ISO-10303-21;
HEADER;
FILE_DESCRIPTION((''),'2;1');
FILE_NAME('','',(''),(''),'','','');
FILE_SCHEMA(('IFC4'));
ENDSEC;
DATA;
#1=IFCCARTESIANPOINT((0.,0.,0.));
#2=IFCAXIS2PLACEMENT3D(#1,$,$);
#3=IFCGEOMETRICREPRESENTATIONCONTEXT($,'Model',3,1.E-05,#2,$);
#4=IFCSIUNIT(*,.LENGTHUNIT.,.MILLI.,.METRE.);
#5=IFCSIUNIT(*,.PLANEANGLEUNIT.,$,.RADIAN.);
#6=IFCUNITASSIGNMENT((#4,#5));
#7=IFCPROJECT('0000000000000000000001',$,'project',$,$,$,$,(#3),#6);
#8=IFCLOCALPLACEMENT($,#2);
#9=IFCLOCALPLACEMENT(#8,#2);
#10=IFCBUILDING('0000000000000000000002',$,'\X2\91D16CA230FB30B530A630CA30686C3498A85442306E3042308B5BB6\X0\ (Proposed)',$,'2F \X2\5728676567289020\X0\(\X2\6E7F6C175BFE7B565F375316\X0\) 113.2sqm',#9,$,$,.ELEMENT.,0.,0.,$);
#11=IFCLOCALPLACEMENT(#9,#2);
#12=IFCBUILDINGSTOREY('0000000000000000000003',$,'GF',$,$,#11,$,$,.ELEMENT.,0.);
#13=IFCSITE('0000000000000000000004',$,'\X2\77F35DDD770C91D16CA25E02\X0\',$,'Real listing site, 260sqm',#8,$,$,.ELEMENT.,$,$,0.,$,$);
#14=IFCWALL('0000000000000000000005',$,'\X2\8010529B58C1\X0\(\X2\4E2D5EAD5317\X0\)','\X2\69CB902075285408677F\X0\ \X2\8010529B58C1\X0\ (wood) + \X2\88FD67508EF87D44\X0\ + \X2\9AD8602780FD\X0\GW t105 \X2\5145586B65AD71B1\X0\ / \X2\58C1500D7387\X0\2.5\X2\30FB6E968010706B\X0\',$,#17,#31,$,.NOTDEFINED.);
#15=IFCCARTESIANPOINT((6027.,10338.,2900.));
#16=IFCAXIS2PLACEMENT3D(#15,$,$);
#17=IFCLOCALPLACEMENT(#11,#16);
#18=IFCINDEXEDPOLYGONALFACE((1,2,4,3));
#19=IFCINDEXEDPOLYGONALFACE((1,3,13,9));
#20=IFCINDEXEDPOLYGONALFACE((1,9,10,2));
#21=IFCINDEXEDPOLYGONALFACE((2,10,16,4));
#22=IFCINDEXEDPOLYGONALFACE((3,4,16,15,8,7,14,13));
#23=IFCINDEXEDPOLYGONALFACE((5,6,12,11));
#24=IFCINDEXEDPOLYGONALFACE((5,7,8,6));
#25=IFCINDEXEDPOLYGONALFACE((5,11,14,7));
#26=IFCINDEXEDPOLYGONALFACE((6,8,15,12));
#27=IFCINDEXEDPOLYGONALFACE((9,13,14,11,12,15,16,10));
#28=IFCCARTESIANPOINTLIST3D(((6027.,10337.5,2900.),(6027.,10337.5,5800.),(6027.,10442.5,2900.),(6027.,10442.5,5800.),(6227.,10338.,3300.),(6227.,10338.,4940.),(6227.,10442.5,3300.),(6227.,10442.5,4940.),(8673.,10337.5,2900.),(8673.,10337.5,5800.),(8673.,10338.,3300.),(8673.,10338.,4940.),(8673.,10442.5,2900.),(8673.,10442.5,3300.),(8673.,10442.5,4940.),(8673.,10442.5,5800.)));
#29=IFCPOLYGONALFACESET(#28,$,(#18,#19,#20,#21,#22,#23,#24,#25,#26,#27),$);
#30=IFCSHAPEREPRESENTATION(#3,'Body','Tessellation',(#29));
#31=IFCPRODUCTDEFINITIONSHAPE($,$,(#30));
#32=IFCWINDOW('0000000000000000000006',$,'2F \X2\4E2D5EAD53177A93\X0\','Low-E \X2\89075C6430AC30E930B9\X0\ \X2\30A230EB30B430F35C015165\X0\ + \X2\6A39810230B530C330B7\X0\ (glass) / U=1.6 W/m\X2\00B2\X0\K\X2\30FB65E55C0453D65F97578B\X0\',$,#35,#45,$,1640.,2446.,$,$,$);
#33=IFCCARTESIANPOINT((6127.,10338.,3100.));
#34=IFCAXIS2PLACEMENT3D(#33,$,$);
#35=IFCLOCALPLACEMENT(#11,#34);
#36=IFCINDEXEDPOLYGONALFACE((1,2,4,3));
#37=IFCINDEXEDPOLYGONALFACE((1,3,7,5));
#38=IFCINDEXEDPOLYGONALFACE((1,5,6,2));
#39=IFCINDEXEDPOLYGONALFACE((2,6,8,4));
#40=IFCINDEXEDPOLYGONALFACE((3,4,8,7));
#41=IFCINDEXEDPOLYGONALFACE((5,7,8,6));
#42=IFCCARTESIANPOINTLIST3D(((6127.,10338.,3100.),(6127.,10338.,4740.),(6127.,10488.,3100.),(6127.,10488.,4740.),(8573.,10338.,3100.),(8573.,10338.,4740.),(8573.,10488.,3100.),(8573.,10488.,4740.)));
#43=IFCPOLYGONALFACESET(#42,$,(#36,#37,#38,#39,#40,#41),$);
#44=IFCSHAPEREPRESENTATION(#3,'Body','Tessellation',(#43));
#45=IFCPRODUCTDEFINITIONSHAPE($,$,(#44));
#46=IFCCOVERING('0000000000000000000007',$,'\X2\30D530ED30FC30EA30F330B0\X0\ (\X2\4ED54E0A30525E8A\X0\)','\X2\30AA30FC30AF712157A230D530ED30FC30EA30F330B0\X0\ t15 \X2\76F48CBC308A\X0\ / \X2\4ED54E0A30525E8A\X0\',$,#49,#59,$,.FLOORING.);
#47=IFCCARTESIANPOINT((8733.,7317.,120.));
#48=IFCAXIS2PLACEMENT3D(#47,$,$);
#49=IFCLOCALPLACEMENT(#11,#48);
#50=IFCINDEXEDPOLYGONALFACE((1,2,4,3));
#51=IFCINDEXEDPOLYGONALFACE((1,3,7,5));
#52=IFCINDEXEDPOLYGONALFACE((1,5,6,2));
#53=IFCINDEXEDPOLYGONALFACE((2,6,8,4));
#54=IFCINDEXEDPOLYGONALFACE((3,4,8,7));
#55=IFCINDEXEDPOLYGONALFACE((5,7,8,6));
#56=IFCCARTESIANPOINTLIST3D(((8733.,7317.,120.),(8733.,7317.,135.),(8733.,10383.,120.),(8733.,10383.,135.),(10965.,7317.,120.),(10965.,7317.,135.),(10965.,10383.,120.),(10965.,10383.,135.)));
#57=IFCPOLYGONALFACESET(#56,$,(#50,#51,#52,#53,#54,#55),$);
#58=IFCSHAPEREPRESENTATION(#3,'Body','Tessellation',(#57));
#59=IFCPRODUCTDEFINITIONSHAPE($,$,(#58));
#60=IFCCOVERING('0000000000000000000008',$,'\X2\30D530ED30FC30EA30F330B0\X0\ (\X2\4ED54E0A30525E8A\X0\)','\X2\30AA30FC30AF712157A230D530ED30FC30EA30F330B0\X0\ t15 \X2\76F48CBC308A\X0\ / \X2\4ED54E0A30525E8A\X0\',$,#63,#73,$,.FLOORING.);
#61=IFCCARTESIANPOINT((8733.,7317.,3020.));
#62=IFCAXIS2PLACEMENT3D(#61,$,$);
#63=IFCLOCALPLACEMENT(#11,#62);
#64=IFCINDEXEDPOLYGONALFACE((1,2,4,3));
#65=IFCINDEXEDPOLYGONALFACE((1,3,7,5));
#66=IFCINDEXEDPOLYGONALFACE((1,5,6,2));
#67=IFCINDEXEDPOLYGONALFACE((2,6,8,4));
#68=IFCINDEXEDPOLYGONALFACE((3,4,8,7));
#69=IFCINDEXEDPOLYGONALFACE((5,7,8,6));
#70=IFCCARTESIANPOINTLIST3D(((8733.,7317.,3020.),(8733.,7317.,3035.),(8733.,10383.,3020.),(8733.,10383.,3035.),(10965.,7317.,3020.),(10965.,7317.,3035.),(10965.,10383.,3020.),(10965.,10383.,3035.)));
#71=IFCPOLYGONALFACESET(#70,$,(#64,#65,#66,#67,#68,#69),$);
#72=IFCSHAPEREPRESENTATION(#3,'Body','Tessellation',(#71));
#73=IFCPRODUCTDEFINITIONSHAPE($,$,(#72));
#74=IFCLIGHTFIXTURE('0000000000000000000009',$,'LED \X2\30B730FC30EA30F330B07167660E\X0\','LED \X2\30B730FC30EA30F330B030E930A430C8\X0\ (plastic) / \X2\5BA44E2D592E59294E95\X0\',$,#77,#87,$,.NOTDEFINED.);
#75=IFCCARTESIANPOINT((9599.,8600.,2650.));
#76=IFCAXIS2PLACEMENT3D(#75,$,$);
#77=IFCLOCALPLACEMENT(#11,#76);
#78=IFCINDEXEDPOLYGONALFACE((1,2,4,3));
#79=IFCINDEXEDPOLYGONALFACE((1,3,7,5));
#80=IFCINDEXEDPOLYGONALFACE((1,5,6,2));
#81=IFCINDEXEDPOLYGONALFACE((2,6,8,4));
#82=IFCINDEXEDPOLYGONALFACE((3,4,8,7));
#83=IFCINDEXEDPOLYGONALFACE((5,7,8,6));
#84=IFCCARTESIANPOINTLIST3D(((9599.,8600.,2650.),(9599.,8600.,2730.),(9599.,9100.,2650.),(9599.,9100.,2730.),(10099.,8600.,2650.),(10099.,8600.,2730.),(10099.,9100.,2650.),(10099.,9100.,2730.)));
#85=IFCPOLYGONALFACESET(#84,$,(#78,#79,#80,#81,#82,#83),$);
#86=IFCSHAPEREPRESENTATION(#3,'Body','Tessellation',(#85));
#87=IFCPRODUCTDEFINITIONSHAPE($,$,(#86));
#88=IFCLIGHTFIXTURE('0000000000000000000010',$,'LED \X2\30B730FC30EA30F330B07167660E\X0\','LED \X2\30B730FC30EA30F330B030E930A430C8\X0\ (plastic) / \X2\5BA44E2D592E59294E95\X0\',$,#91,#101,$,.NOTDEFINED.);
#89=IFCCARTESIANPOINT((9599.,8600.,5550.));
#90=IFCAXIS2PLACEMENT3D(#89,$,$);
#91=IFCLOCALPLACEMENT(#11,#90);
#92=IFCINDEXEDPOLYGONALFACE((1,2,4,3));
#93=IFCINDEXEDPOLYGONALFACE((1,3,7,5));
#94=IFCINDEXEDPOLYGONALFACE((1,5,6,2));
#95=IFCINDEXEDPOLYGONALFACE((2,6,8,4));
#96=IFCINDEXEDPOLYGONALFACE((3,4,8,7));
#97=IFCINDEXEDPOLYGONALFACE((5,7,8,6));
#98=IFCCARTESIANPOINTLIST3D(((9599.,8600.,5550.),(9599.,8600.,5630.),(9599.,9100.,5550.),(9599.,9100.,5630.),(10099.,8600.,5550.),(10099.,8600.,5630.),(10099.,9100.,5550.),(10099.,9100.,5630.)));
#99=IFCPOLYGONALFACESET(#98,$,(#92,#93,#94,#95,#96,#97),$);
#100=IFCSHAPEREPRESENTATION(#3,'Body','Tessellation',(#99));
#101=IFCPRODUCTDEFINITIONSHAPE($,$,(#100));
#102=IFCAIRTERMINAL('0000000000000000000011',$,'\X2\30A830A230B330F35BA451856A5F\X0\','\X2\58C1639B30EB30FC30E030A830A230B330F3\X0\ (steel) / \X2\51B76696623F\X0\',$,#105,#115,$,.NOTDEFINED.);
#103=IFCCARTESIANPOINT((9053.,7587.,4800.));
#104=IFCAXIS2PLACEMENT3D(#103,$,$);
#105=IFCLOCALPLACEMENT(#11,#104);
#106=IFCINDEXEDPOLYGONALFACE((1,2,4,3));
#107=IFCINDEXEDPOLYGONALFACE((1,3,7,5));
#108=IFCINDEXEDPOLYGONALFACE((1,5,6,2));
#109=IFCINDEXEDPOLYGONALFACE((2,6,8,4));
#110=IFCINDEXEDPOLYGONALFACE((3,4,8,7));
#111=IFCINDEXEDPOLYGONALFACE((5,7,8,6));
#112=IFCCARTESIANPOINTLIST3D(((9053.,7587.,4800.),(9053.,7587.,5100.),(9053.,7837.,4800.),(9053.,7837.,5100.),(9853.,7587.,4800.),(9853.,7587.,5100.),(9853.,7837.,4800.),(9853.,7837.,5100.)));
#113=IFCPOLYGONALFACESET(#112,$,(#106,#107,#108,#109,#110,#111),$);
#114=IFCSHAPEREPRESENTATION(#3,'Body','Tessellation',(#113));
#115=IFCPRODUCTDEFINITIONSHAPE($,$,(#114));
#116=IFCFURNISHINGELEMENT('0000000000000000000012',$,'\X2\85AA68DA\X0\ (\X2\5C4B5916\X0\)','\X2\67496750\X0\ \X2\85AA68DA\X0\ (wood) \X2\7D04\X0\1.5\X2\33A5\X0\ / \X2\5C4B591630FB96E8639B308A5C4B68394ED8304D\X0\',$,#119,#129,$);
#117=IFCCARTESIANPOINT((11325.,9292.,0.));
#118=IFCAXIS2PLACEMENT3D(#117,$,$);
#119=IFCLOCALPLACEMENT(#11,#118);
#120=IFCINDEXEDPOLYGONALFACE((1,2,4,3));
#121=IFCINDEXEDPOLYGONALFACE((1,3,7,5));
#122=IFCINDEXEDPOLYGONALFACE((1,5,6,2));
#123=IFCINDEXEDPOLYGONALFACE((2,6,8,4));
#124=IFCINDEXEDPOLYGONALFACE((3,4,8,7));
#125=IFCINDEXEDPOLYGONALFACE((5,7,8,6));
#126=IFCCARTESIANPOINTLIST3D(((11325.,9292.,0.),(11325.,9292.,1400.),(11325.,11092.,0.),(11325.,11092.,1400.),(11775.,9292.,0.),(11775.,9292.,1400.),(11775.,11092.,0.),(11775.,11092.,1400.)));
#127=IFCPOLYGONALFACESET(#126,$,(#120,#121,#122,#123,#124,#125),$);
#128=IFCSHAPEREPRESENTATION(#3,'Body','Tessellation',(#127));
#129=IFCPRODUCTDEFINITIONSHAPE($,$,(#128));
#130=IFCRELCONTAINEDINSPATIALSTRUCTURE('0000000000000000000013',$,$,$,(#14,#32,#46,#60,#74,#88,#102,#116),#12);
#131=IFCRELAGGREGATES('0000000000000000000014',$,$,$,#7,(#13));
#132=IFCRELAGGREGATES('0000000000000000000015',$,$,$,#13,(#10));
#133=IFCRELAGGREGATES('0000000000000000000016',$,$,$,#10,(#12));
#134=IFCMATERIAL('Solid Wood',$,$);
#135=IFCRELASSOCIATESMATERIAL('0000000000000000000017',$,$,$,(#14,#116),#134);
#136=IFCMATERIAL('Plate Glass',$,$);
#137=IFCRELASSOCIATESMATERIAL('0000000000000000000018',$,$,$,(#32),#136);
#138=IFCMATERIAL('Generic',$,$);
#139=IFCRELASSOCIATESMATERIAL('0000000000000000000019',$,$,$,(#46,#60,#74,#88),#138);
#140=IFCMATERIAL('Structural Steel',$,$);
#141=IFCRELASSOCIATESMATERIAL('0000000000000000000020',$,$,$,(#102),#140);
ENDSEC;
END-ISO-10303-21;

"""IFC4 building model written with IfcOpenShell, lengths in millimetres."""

from ifc_helpers import new_model, si_unit, frame, frame_2d, origin, place, context, project, spatial, rectangle, extrude, material, element, fill, save


model = new_model("IFC4")

# Units and contexts
model_context = context("Model", 3, precision=1e-05, world=origin())
ifc_project = project(units=[si_unit("LENGTHUNIT", "METRE", prefix="MILLI"), si_unit("PLANEANGLEUNIT", "RADIAN")], contexts=[model_context])

# Site, building, storey
site_placement = place(None, origin())
site = spatial("IfcSite", under=ifc_project, at=site_placement, Name="石川県金沢市", ObjectType="Real listing site, 260sqm", CompositionType="ELEMENT", RefElevation=0.0)
building_placement = place(site_placement, origin())
building = spatial("IfcBuilding", under=site, at=building_placement, Name="金沢・サウナと水風呂のある家 (Proposed)", ObjectType="2F 在来木造(湿気対策強化) 113.2sqm", CompositionType="ELEMENT", ElevationOfRefHeight=0.0, ElevationOfTerrain=0.0)
storey_placement = place(building_placement, origin())
storey = spatial("IfcBuildingStorey", under=building, at=storey_placement, Name="GF", CompositionType="ELEMENT", Elevation=0.0)

# Shared definitions
ifc_material_1 = material(Name="Solid Wood")

# Wall, opening, window
ifc_material_2 = material(Name="Plate Glass")
wall_1_placement = place(storey_placement, frame((6027.0, 10338.0, 2900.0)))
wall_1 = element("IfcWall", 1, at=wall_1_placement, inside=storey, material=ifc_material_1, Name="耐力壁(中庭北)", Description="構造用合板 耐力壁 (wood) + 製材軸組 + 高性能GW t105 充填断熱 / 壁倍率2.5・準耐火", PredefinedType="NOTDEFINED", context=model_context, shape_type="SweptSolid", body=[
    extrude(rectangle(XDim=2646.0, YDim=105.0, at=frame_2d((1323.0, 52.0))), frame((6027.0, 10338.0, 2900.0)), (0.0, 0.0, 1.0), 2900.0),
])
opening_1_placement = place(storey_placement, frame((6127.0, 10338.0, 3100.0)))
opening_1 = element("IfcOpeningElement", 2, at=opening_1_placement, cuts=wall_1, PredefinedType="NOTDEFINED", context=model_context, shape_type="SweptSolid", body=[
    extrude(rectangle(XDim=2446.0, YDim=150.0, at=frame_2d((1223.0, 75.0))), frame((6127.0, 10338.0, 3100.0)), (0.0, 0.0, 1.0), 1640.0),
])
window_1_placement = place(storey_placement, frame((6127.0, 10338.0, 3100.0)))
window_1 = element("IfcWindow", 3, at=window_1_placement, inside=storey, material=ifc_material_2, Name="2F 中庭北窓", Description="Low-E 複層ガラス アルゴン封入 + 樹脂サッシ (glass) / U=1.6 W/m²K・日射取得型", OverallHeight=1640.0, OverallWidth=2446.0, context=model_context, shape_type="SweptSolid", body=[
    extrude(rectangle(XDim=2446.0, YDim=150.0, at=frame_2d((1223.0, 75.0))), frame((6127.0, 10338.0, 3100.0)), (0.0, 0.0, 1.0), 1640.0),
])
fill(opening_1, window_1)

# Coverings
ifc_material_3 = material(Name="Generic")
covering_1_placement = place(storey_placement, frame((8733.0, 7317.0, 120.0)))
element("IfcCovering", 4, at=covering_1_placement, inside=storey, material=ifc_material_3, Name="フローリング (仕上げ床)", Description="オーク無垢フローリング t15 直貼り / 仕上げ床", PredefinedType="FLOORING", context=model_context, shape_type="SweptSolid", body=[
    extrude(rectangle(XDim=2232.0, YDim=3066.0, at=frame_2d((1116.0, 1533.0))), frame((8733.0, 7317.0, 120.0)), (0.0, 0.0, 1.0), 15.0),
])
covering_2_placement = place(storey_placement, frame((8733.0, 7317.0, 3020.0)))
element("IfcCovering", 5, at=covering_2_placement, inside=storey, material=ifc_material_3, Name="フローリング (仕上げ床)", Description="オーク無垢フローリング t15 直貼り / 仕上げ床", PredefinedType="FLOORING", context=model_context, shape_type="SweptSolid", body=[
    extrude(rectangle(XDim=2232.0, YDim=3066.0, at=frame_2d((1116.0, 1533.0))), frame((8733.0, 7317.0, 3020.0)), (0.0, 0.0, 1.0), 15.0),
])

# Light fixtures
light_fixture_1_placement = place(storey_placement, frame((9599.0, 8600.0, 2650.0)))
element("IfcLightFixture", 6, at=light_fixture_1_placement, inside=storey, material=ifc_material_3, Name="LED シーリング照明", Description="LED シーリングライト (plastic) / 室中央天井", PredefinedType="NOTDEFINED", context=model_context, shape_type="SweptSolid", body=[
    extrude(rectangle(XDim=500.0, YDim=500.0, at=frame_2d((250.0, 250.0))), frame((9599.0, 8600.0, 2650.0)), (0.0, 0.0, 1.0), 80.0),
])
light_fixture_2_placement = place(storey_placement, frame((9599.0, 8600.0, 5550.0)))
element("IfcLightFixture", 7, at=light_fixture_2_placement, inside=storey, material=ifc_material_3, Name="LED シーリング照明", Description="LED シーリングライト (plastic) / 室中央天井", PredefinedType="NOTDEFINED", context=model_context, shape_type="SweptSolid", body=[
    extrude(rectangle(XDim=500.0, YDim=500.0, at=frame_2d((250.0, 250.0))), frame((9599.0, 8600.0, 5550.0)), (0.0, 0.0, 1.0), 80.0),
])

# Air terminal
ifc_material_4 = material(Name="Structural Steel")
air_terminal_placement = place(storey_placement, frame((9053.0, 7587.0, 4800.0)))
element("IfcAirTerminal", 8, at=air_terminal_placement, inside=storey, material=ifc_material_4, Name="エアコン室内機", Description="壁掛ルームエアコン (steel) / 冷暖房", PredefinedType="NOTDEFINED", context=model_context, shape_type="SweptSolid", body=[
    extrude(rectangle(XDim=800.0, YDim=250.0, at=frame_2d((400.0, 125.0))), frame((9053.0, 7587.0, 4800.0)), (0.0, 0.0, 1.0), 300.0),
])

# Furnishing element
furnishing_placement = place(storey_placement, frame((11325.0, 9292.0, 0.0)))
element("IfcFurnishingElement", 9, at=furnishing_placement, inside=storey, material=ifc_material_1, Name="薪棚 (屋外)", Description="杉材 薪棚 (wood) 約1.5㎥ / 屋外・雨掛り屋根付き", context=model_context, shape_type="SweptSolid", body=[
    extrude(rectangle(XDim=450.0, YDim=1800.0, at=frame_2d((225.0, 900.0))), frame((11325.0, 9292.0, 0.0)), (0.0, 0.0, 1.0), 1400.0),
])

save(model, "model.ifc")
